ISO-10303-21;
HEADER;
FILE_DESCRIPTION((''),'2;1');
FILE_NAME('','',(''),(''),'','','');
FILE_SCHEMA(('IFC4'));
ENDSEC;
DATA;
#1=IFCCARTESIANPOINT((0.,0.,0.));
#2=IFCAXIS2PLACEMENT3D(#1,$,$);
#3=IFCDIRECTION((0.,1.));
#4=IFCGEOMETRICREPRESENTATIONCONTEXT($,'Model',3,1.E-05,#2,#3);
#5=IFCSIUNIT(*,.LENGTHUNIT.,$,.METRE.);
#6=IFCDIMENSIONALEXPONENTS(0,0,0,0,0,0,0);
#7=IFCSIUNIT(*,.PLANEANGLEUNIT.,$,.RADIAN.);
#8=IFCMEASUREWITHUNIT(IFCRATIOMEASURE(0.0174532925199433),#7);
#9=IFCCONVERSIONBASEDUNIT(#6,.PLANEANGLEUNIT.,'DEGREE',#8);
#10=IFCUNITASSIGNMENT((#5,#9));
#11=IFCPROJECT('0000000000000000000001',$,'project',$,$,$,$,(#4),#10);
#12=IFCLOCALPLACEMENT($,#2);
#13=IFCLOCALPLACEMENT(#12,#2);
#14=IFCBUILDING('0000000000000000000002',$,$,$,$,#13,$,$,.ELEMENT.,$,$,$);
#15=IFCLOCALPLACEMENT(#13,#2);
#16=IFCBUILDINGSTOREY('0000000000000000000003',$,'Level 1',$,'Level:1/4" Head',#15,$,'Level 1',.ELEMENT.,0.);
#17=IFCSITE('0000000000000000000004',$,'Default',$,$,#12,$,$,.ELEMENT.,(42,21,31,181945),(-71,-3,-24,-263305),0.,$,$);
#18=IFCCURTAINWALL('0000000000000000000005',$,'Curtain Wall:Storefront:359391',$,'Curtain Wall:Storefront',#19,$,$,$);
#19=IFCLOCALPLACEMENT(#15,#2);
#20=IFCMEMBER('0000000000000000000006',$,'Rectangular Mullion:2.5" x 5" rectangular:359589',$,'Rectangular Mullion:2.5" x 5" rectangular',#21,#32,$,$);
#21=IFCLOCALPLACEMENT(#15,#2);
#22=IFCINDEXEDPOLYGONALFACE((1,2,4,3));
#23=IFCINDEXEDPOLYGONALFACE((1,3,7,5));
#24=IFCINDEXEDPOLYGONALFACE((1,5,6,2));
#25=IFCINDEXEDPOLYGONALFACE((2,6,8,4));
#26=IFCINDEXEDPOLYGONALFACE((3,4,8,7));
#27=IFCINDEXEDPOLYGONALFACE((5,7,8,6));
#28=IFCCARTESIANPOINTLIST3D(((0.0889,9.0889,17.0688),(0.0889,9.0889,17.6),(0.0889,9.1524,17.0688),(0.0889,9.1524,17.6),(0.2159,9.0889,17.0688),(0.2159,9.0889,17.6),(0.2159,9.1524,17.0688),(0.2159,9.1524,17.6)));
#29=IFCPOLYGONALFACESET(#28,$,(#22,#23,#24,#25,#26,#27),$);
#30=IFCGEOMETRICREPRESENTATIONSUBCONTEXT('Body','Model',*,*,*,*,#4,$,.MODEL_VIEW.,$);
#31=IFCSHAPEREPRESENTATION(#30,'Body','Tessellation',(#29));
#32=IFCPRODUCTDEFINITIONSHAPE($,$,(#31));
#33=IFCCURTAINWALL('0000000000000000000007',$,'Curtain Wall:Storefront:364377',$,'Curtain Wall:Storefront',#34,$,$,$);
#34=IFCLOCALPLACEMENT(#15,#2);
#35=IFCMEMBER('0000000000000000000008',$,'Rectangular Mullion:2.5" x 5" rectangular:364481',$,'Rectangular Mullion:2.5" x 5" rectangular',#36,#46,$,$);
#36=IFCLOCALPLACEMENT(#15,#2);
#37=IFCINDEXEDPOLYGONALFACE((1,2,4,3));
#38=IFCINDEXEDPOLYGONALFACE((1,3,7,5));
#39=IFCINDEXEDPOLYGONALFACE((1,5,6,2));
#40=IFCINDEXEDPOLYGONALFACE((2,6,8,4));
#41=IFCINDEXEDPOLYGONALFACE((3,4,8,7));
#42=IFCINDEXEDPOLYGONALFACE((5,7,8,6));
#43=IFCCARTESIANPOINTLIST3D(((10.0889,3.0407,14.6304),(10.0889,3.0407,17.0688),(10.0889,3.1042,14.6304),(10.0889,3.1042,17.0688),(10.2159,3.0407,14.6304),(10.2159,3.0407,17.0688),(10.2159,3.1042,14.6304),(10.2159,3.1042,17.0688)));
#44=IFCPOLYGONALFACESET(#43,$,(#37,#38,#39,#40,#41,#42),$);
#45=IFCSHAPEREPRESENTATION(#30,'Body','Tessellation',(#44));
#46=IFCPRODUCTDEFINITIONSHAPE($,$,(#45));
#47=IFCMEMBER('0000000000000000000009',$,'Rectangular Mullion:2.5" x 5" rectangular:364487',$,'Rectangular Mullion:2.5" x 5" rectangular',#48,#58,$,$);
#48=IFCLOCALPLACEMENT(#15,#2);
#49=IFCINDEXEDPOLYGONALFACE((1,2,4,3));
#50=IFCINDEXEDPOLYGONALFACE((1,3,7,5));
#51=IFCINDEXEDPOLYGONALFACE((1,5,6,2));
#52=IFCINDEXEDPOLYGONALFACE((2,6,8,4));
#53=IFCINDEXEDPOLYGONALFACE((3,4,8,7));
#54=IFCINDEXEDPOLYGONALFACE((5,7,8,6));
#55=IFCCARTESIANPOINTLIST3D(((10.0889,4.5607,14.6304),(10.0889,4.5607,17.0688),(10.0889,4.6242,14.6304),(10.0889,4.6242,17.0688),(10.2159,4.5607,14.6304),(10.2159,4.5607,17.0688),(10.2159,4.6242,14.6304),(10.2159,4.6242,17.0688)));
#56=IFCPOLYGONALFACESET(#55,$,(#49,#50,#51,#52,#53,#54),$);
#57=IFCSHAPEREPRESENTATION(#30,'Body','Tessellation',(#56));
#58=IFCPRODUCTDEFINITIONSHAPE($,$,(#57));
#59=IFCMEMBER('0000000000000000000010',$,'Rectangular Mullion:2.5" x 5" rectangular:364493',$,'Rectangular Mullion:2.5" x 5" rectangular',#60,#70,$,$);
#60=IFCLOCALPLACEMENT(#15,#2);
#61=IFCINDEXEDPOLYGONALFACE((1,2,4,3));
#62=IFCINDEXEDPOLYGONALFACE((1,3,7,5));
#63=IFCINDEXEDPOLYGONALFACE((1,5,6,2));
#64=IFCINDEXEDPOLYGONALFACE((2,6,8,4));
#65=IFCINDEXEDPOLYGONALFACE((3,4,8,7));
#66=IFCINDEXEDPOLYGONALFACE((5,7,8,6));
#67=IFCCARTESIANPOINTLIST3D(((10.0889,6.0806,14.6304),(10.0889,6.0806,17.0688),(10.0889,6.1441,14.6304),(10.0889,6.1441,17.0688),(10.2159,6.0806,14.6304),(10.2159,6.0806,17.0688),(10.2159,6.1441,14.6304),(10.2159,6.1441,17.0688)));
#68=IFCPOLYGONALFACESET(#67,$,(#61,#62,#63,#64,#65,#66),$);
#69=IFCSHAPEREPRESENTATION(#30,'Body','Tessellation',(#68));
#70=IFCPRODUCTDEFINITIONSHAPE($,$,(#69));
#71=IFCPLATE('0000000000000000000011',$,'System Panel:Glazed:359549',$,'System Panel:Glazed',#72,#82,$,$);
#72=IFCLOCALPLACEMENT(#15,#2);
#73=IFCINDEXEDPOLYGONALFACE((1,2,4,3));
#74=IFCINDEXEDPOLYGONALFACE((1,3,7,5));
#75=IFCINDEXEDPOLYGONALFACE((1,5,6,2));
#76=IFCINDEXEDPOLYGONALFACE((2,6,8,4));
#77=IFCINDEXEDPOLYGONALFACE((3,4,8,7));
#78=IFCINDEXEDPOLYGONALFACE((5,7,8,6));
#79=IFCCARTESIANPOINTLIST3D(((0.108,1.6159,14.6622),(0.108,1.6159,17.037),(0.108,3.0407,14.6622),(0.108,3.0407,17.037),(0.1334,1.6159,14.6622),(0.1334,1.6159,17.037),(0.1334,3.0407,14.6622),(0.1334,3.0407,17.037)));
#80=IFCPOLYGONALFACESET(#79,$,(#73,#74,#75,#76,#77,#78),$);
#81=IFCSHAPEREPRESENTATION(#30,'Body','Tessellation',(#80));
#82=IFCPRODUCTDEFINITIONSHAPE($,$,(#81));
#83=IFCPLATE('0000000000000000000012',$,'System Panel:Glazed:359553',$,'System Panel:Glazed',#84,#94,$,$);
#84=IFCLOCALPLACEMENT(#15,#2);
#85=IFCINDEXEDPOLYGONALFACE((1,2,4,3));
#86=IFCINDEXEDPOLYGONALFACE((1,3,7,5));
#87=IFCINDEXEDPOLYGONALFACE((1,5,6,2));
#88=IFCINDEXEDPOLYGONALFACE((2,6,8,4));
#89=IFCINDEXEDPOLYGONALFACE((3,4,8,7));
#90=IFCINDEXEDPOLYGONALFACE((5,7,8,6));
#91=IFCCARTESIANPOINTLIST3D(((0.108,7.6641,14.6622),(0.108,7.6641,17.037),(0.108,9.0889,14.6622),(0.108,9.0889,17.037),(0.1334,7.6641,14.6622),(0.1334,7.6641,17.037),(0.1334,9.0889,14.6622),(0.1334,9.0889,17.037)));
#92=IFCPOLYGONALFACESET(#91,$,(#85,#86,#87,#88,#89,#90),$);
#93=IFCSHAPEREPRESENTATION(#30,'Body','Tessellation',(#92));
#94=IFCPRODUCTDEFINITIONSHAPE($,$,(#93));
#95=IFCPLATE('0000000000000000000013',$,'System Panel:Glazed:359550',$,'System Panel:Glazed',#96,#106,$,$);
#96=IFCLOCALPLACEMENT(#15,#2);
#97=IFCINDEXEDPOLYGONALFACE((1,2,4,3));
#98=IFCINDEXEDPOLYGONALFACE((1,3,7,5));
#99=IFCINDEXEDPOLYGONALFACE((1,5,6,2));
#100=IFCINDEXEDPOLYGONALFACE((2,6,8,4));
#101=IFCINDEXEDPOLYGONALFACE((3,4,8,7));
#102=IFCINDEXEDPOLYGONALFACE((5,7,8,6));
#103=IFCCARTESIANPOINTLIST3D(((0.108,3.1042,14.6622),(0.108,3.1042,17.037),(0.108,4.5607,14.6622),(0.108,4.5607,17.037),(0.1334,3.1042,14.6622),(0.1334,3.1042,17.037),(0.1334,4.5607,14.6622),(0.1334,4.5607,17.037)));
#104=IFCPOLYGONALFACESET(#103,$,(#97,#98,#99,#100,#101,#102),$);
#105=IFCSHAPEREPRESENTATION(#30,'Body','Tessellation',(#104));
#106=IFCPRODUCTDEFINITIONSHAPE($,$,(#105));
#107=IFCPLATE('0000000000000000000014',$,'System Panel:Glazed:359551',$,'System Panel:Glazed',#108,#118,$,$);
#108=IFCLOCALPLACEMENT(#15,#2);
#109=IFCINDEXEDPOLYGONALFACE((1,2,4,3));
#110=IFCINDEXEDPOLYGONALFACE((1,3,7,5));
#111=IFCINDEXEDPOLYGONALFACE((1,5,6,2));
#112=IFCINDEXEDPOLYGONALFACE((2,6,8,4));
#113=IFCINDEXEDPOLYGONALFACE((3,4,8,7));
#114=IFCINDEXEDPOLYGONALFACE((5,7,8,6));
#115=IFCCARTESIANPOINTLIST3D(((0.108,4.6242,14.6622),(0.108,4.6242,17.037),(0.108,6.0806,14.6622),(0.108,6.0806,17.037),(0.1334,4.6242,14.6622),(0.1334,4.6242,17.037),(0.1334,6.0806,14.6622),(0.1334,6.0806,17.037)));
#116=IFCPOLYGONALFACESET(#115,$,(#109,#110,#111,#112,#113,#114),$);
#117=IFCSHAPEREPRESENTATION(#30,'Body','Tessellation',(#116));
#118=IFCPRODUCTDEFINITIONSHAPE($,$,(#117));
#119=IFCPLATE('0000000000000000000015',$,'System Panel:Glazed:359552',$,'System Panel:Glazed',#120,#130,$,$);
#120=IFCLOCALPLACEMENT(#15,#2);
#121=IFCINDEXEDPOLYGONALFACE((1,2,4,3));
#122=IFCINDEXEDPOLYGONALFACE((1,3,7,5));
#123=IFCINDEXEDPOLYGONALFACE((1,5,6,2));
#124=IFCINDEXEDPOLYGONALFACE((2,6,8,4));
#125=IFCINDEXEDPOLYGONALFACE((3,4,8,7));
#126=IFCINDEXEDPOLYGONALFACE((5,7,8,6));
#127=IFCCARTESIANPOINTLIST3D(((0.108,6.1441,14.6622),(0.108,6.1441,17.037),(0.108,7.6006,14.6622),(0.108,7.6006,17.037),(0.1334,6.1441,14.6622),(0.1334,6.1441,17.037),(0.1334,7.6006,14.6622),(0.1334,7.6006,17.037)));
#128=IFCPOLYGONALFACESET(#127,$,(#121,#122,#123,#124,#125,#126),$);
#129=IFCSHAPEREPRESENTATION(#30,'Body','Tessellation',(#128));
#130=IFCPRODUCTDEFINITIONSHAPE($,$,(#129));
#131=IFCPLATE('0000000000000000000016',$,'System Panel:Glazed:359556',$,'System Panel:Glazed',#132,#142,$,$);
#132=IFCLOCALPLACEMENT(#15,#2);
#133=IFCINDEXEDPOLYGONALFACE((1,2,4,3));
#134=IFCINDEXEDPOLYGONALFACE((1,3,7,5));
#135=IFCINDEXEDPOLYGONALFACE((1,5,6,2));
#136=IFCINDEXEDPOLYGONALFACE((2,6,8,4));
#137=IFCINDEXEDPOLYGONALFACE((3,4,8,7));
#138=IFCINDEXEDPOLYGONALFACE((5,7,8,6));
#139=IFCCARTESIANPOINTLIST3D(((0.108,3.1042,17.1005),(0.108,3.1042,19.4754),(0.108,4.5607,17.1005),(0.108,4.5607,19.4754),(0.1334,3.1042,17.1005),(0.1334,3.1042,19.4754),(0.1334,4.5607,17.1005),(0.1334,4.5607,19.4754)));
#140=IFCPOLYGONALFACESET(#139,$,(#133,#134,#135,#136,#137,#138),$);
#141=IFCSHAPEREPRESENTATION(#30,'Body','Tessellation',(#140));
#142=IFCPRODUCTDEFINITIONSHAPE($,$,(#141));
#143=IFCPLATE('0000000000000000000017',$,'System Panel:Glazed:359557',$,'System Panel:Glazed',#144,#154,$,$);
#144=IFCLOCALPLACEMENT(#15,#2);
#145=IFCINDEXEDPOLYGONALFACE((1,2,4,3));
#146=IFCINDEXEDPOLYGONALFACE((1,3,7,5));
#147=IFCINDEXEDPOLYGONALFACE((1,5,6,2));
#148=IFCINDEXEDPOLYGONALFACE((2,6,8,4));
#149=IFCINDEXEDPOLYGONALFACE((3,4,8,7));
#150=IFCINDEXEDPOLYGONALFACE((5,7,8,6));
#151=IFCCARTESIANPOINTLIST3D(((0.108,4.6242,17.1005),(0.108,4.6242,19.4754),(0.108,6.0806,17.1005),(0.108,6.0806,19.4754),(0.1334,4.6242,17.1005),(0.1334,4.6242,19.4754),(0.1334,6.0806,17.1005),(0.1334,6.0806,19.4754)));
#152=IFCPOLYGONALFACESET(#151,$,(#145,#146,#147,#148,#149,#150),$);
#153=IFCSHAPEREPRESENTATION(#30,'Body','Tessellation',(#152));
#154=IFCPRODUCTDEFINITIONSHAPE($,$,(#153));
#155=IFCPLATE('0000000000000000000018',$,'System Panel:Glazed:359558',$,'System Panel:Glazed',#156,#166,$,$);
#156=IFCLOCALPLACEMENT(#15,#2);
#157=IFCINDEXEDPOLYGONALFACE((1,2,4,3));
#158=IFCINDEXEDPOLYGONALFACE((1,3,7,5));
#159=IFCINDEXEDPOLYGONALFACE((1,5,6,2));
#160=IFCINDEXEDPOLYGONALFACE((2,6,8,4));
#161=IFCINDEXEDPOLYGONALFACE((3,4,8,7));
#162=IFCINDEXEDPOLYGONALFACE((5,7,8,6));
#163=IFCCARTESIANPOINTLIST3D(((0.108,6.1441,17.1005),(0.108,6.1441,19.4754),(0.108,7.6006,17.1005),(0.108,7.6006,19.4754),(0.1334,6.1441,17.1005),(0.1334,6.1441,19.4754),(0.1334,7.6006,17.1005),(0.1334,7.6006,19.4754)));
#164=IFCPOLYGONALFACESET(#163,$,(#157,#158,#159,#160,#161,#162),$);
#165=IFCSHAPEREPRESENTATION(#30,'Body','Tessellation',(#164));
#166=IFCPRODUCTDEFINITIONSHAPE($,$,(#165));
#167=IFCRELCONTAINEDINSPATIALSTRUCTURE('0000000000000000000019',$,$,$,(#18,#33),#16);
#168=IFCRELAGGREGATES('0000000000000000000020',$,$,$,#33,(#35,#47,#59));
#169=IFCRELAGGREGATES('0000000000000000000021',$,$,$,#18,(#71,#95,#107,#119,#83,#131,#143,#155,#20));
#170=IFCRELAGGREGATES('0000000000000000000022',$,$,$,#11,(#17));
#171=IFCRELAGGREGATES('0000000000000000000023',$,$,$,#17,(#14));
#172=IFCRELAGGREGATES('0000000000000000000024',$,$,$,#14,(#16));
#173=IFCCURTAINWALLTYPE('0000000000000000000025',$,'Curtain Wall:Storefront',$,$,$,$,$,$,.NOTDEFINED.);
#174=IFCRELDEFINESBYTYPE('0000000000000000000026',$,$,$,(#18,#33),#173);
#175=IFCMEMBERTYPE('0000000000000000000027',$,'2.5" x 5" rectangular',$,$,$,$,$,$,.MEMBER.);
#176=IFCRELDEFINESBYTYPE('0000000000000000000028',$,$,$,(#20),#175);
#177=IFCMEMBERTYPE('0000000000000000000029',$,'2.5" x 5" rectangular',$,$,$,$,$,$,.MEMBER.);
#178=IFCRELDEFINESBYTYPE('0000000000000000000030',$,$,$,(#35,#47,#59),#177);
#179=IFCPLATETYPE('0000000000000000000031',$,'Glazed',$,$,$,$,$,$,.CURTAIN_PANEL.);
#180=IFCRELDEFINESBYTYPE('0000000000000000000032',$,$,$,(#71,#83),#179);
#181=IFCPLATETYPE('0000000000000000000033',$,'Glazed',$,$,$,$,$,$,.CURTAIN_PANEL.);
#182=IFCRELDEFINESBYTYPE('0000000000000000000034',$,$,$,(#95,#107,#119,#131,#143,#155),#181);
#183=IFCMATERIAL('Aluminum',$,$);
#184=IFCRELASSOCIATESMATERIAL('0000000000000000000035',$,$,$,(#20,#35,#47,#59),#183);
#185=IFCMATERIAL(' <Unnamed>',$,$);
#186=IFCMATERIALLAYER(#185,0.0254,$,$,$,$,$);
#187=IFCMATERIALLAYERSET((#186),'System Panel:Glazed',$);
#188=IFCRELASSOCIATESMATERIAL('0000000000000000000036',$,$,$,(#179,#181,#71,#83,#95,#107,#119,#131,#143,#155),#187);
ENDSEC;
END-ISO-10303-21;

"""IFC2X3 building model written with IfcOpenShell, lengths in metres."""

from ifc_helpers import new_model, entity, si_unit, converted_unit, direction, frame, frame_2d, origin, origin_2d_with_axis, place, context, subcontext, project, spatial, rectangle, extrude, source, transform, mapped, material, layer, layer_set, layer_usage, type_object, type_shapes, element, aggregate, save


model = new_model("IFC2X3")

# Units and contexts
model_context = context("Model", 3, precision=1e-05, world=origin(), true_north=direction((0.0, 1.0)))
body_context = subcontext(model_context, "Body", "Model", "MODEL_VIEW")
ifc_project = project(units=[si_unit("LENGTHUNIT", "METRE"), converted_unit("PLANEANGLEUNIT", "DEGREE", entity("IfcRatioMeasure", 0.0174532925199433), si_unit("PLANEANGLEUNIT", "RADIAN"), dimensions=[0, 0, 0, 0, 0, 0, 0])], contexts=[model_context])

# Site, building, storey
site_placement = place(None, origin())
site = spatial("IfcSite", under=ifc_project, at=site_placement, Name="Default", CompositionType="ELEMENT", RefLatitude=(42, 21, 31, 181945), RefLongitude=(-71, -3, -24, -263305), RefElevation=0.0)
building_placement = place(site_placement, origin())
building = spatial("IfcBuilding", under=site, at=building_placement, CompositionType="ELEMENT")
storey_placement = place(building_placement, origin())
storey = spatial("IfcBuildingStorey", under=building, at=storey_placement, Name="Level 1", ObjectType="Level:1/4\" Head", LongName="Level 1", CompositionType="ELEMENT", Elevation=0.0)

# Curtain walls, members
curtain_wall_type = type_object("IfcCurtainWallType", Name="Curtain Wall:Storefront", PredefinedType="NOTDEFINED")
curtain_wall_1_placement = place(storey_placement, origin())
curtain_wall_1 = element("IfcCurtainWall", 1, at=curtain_wall_1_placement, inside=storey, type_object=curtain_wall_type, Name="Curtain Wall:Storefront:359391", ObjectType="Curtain Wall:Storefront")
ifc_material_1 = material(Name="Aluminum")
member_type_1 = type_object("IfcMemberType", Name="2.5\" x 5\" rectangular", PredefinedType="MEMBER")
shared_shape_1 = source(origin(), body_context, "Body", "SweptSolid", [
    extrude(rectangle(XDim=0.127, YDim=0.0635, at=origin_2d_with_axis()), frame((-0.0318, 0.0, -0.5312), z_axis=(0.0, 0.0, 1.0), x_axis=(0.0, -1.0, 0.0)), (0.0, 0.0, 1.0), 0.5312),
])
type_shapes(member_type_1, [shared_shape_1])
member_1_placement = place(storey_placement, frame((0.1524, 9.1524, 17.0688), z_axis=(0.0, 0.0, -1.0), x_axis=(0.0, 1.0, 0.0)))
member_1 = element("IfcMember", 2, at=member_1_placement, type_object=member_type_1, material=ifc_material_1, Name="Rectangular Mullion:2.5\" x 5\" rectangular:359589", ObjectType="Rectangular Mullion:2.5\" x 5\" rectangular", context=body_context, shape_type="MappedRepresentation", body=[
    mapped(shared_shape_1, transform((0.0, 0.0, 0.0), scale=1.0)),
])
curtain_wall_2_placement = place(storey_placement, origin())
curtain_wall_2 = element("IfcCurtainWall", 3, at=curtain_wall_2_placement, inside=storey, type_object=curtain_wall_type, Name="Curtain Wall:Storefront:364377", ObjectType="Curtain Wall:Storefront")
member_type_2 = type_object("IfcMemberType", Name="2.5\" x 5\" rectangular", PredefinedType="MEMBER")
shared_shape_2 = source(origin(), body_context, "Body", "SweptSolid", [
    extrude(rectangle(XDim=0.127, YDim=0.0635, at=origin_2d_with_axis()), frame((0.0, 0.0, -2.4384), z_axis=(0.0, 0.0, 1.0), x_axis=(0.0, -1.0, 0.0)), (0.0, 0.0, 1.0), 2.4384),
])
type_shapes(member_type_2, [shared_shape_2])
member_2_placement = place(storey_placement, frame((10.1524, 3.0724, 14.6304), z_axis=(0.0, 0.0, -1.0), x_axis=(0.0, 1.0, 0.0)))
member_2 = element("IfcMember", 4, at=member_2_placement, type_object=member_type_2, material=ifc_material_1, Name="Rectangular Mullion:2.5\" x 5\" rectangular:364481", ObjectType="Rectangular Mullion:2.5\" x 5\" rectangular", context=body_context, shape_type="MappedRepresentation", body=[
    mapped(shared_shape_2, transform((0.0, 0.0, 0.0), scale=1.0)),
])
member_3_placement = place(storey_placement, frame((10.1524, 4.5924, 14.6304), z_axis=(0.0, 0.0, -1.0), x_axis=(0.0, 1.0, 0.0)))
member_3 = element("IfcMember", 5, at=member_3_placement, type_object=member_type_2, material=ifc_material_1, Name="Rectangular Mullion:2.5\" x 5\" rectangular:364487", ObjectType="Rectangular Mullion:2.5\" x 5\" rectangular", context=body_context, shape_type="MappedRepresentation", body=[
    mapped(shared_shape_2, transform((0.0, 0.0, 0.0), scale=1.0)),
])
member_4_placement = place(storey_placement, frame((10.1524, 6.1124, 14.6304), z_axis=(0.0, 0.0, -1.0), x_axis=(0.0, 1.0, 0.0)))
member_4 = element("IfcMember", 6, at=member_4_placement, type_object=member_type_2, material=ifc_material_1, Name="Rectangular Mullion:2.5\" x 5\" rectangular:364493", ObjectType="Rectangular Mullion:2.5\" x 5\" rectangular", context=body_context, shape_type="MappedRepresentation", body=[
    mapped(shared_shape_2, transform((0.0, 0.0, 0.0), scale=1.0)),
])
aggregate(curtain_wall_2, [member_2, member_3, member_4])

# Plates
ifc_material_2 = material(Name=" <Unnamed>")
ifc_layer = layer(ifc_material_2, 0.0254)
ifc_layer_set = layer_set([ifc_layer], Name="System Panel:Glazed")
ifc_layer_usage_1 = layer_usage(ifc_layer_set, "AXIS3", "POSITIVE", 0.1042)
plate_type_1 = type_object("IfcPlateType", Name="Glazed", PredefinedType="CURTAIN_PANEL", material=ifc_layer_set)
shared_shape_3 = source(origin(), body_context, "Body", "SweptSolid", [
    extrude(rectangle(XDim=0.0254, YDim=1.4248, at=frame_2d((0.0, 0.0), x_axis=(1.0, 0.0))), frame((0.7124, 0.0127, 0.0), z_axis=(0.0, 0.0, 1.0), x_axis=(0.0, 1.0, 0.0)), (0.0, 0.0, 1.0), 2.3749),
])
type_shapes(plate_type_1, [shared_shape_3])
plate_1_placement = place(curtain_wall_1_placement, frame((0.1334, 1.6159, 14.6622), z_axis=(0.0, 0.0, 1.0), x_axis=(0.0, 1.0, 0.0)))
plate_1 = element("IfcPlate", 7, at=plate_1_placement, type_object=plate_type_1, material=ifc_layer_usage_1, Name="System Panel:Glazed:359549", ObjectType="System Panel:Glazed", context=body_context, shape_type="MappedRepresentation", body=[
    mapped(shared_shape_3, transform((0.0, 0.0, 0.0), scale=1.0)),
])
ifc_layer_usage_2 = layer_usage(ifc_layer_set, "AXIS3", "POSITIVE", 0.1042)
plate_2_placement = place(curtain_wall_1_placement, frame((0.1334, 7.6641, 14.6622), z_axis=(0.0, 0.0, 1.0), x_axis=(0.0, 1.0, 0.0)))
plate_2 = element("IfcPlate", 8, at=plate_2_placement, type_object=plate_type_1, material=ifc_layer_usage_2, Name="System Panel:Glazed:359553", ObjectType="System Panel:Glazed", context=body_context, shape_type="MappedRepresentation", body=[
    mapped(shared_shape_3, transform((0.0, 0.0, 0.0), scale=1.0)),
])
ifc_layer_usage_3 = layer_usage(ifc_layer_set, "AXIS3", "POSITIVE", 0.1042)
plate_type_2 = type_object("IfcPlateType", Name="Glazed", PredefinedType="CURTAIN_PANEL", material=ifc_layer_set)
shared_shape_4 = source(origin(), body_context, "Body", "SweptSolid", [
    extrude(rectangle(XDim=0.0254, YDim=1.4565, at=frame_2d((0.0, 0.0), x_axis=(1.0, 0.0))), frame((0.7282, 0.0127, 0.0), z_axis=(0.0, 0.0, 1.0), x_axis=(0.0, 1.0, 0.0)), (0.0, 0.0, 1.0), 2.3749),
])
type_shapes(plate_type_2, [shared_shape_4])
plate_3_placement = place(curtain_wall_1_placement, frame((0.1334, 3.1042, 14.6622), z_axis=(0.0, 0.0, 1.0), x_axis=(0.0, 1.0, 0.0)))
plate_3 = element("IfcPlate", 9, at=plate_3_placement, type_object=plate_type_2, material=ifc_layer_usage_3, Name="System Panel:Glazed:359550", ObjectType="System Panel:Glazed", context=body_context, shape_type="MappedRepresentation", body=[
    mapped(shared_shape_4, transform((0.0, 0.0, 0.0), scale=1.0)),
])
ifc_layer_usage_4 = layer_usage(ifc_layer_set, "AXIS3", "POSITIVE", 0.1042)
plate_4_placement = place(curtain_wall_1_placement, frame((0.1334, 4.6242, 14.6622), z_axis=(0.0, 0.0, 1.0), x_axis=(0.0, 1.0, 0.0)))
plate_4 = element("IfcPlate", 10, at=plate_4_placement, type_object=plate_type_2, material=ifc_layer_usage_4, Name="System Panel:Glazed:359551", ObjectType="System Panel:Glazed", context=body_context, shape_type="MappedRepresentation", body=[
    mapped(shared_shape_4, transform((0.0, 0.0, 0.0), scale=1.0)),
])
ifc_layer_usage_5 = layer_usage(ifc_layer_set, "AXIS3", "POSITIVE", 0.1042)
plate_5_placement = place(curtain_wall_1_placement, frame((0.1334, 6.1441, 14.6622), z_axis=(0.0, 0.0, 1.0), x_axis=(0.0, 1.0, 0.0)))
plate_5 = element("IfcPlate", 11, at=plate_5_placement, type_object=plate_type_2, material=ifc_layer_usage_5, Name="System Panel:Glazed:359552", ObjectType="System Panel:Glazed", context=body_context, shape_type="MappedRepresentation", body=[
    mapped(shared_shape_4, transform((0.0, 0.0, 0.0), scale=1.0)),
])
ifc_layer_usage_6 = layer_usage(ifc_layer_set, "AXIS3", "POSITIVE", 0.1042)
plate_6_placement = place(curtain_wall_1_placement, frame((0.1334, 3.1042, 17.1005), z_axis=(0.0, 0.0, 1.0), x_axis=(0.0, 1.0, 0.0)))
plate_6 = element("IfcPlate", 12, at=plate_6_placement, type_object=plate_type_2, material=ifc_layer_usage_6, Name="System Panel:Glazed:359556", ObjectType="System Panel:Glazed", context=body_context, shape_type="MappedRepresentation", body=[
    mapped(shared_shape_4, transform((0.0, 0.0, 0.0), scale=1.0)),
])
ifc_layer_usage_7 = layer_usage(ifc_layer_set, "AXIS3", "POSITIVE", 0.1042)
plate_7_placement = place(curtain_wall_1_placement, frame((0.1334, 4.6242, 17.1005), z_axis=(0.0, 0.0, 1.0), x_axis=(0.0, 1.0, 0.0)))
plate_7 = element("IfcPlate", 13, at=plate_7_placement, type_object=plate_type_2, material=ifc_layer_usage_7, Name="System Panel:Glazed:359557", ObjectType="System Panel:Glazed", context=body_context, shape_type="MappedRepresentation", body=[
    mapped(shared_shape_4, transform((0.0, 0.0, 0.0), scale=1.0)),
])
ifc_layer_usage_8 = layer_usage(ifc_layer_set, "AXIS3", "POSITIVE", 0.1042)
plate_8_placement = place(curtain_wall_1_placement, frame((0.1334, 6.1441, 17.1005), z_axis=(0.0, 0.0, 1.0), x_axis=(0.0, 1.0, 0.0)))
plate_8 = element("IfcPlate", 14, at=plate_8_placement, type_object=plate_type_2, material=ifc_layer_usage_8, Name="System Panel:Glazed:359558", ObjectType="System Panel:Glazed", context=body_context, shape_type="MappedRepresentation", body=[
    mapped(shared_shape_4, transform((0.0, 0.0, 0.0), scale=1.0)),
])
aggregate(curtain_wall_1, [plate_1, plate_3, plate_4, plate_5, plate_2, plate_6, plate_7, plate_8, member_1])

save(model, "model.ifc")
